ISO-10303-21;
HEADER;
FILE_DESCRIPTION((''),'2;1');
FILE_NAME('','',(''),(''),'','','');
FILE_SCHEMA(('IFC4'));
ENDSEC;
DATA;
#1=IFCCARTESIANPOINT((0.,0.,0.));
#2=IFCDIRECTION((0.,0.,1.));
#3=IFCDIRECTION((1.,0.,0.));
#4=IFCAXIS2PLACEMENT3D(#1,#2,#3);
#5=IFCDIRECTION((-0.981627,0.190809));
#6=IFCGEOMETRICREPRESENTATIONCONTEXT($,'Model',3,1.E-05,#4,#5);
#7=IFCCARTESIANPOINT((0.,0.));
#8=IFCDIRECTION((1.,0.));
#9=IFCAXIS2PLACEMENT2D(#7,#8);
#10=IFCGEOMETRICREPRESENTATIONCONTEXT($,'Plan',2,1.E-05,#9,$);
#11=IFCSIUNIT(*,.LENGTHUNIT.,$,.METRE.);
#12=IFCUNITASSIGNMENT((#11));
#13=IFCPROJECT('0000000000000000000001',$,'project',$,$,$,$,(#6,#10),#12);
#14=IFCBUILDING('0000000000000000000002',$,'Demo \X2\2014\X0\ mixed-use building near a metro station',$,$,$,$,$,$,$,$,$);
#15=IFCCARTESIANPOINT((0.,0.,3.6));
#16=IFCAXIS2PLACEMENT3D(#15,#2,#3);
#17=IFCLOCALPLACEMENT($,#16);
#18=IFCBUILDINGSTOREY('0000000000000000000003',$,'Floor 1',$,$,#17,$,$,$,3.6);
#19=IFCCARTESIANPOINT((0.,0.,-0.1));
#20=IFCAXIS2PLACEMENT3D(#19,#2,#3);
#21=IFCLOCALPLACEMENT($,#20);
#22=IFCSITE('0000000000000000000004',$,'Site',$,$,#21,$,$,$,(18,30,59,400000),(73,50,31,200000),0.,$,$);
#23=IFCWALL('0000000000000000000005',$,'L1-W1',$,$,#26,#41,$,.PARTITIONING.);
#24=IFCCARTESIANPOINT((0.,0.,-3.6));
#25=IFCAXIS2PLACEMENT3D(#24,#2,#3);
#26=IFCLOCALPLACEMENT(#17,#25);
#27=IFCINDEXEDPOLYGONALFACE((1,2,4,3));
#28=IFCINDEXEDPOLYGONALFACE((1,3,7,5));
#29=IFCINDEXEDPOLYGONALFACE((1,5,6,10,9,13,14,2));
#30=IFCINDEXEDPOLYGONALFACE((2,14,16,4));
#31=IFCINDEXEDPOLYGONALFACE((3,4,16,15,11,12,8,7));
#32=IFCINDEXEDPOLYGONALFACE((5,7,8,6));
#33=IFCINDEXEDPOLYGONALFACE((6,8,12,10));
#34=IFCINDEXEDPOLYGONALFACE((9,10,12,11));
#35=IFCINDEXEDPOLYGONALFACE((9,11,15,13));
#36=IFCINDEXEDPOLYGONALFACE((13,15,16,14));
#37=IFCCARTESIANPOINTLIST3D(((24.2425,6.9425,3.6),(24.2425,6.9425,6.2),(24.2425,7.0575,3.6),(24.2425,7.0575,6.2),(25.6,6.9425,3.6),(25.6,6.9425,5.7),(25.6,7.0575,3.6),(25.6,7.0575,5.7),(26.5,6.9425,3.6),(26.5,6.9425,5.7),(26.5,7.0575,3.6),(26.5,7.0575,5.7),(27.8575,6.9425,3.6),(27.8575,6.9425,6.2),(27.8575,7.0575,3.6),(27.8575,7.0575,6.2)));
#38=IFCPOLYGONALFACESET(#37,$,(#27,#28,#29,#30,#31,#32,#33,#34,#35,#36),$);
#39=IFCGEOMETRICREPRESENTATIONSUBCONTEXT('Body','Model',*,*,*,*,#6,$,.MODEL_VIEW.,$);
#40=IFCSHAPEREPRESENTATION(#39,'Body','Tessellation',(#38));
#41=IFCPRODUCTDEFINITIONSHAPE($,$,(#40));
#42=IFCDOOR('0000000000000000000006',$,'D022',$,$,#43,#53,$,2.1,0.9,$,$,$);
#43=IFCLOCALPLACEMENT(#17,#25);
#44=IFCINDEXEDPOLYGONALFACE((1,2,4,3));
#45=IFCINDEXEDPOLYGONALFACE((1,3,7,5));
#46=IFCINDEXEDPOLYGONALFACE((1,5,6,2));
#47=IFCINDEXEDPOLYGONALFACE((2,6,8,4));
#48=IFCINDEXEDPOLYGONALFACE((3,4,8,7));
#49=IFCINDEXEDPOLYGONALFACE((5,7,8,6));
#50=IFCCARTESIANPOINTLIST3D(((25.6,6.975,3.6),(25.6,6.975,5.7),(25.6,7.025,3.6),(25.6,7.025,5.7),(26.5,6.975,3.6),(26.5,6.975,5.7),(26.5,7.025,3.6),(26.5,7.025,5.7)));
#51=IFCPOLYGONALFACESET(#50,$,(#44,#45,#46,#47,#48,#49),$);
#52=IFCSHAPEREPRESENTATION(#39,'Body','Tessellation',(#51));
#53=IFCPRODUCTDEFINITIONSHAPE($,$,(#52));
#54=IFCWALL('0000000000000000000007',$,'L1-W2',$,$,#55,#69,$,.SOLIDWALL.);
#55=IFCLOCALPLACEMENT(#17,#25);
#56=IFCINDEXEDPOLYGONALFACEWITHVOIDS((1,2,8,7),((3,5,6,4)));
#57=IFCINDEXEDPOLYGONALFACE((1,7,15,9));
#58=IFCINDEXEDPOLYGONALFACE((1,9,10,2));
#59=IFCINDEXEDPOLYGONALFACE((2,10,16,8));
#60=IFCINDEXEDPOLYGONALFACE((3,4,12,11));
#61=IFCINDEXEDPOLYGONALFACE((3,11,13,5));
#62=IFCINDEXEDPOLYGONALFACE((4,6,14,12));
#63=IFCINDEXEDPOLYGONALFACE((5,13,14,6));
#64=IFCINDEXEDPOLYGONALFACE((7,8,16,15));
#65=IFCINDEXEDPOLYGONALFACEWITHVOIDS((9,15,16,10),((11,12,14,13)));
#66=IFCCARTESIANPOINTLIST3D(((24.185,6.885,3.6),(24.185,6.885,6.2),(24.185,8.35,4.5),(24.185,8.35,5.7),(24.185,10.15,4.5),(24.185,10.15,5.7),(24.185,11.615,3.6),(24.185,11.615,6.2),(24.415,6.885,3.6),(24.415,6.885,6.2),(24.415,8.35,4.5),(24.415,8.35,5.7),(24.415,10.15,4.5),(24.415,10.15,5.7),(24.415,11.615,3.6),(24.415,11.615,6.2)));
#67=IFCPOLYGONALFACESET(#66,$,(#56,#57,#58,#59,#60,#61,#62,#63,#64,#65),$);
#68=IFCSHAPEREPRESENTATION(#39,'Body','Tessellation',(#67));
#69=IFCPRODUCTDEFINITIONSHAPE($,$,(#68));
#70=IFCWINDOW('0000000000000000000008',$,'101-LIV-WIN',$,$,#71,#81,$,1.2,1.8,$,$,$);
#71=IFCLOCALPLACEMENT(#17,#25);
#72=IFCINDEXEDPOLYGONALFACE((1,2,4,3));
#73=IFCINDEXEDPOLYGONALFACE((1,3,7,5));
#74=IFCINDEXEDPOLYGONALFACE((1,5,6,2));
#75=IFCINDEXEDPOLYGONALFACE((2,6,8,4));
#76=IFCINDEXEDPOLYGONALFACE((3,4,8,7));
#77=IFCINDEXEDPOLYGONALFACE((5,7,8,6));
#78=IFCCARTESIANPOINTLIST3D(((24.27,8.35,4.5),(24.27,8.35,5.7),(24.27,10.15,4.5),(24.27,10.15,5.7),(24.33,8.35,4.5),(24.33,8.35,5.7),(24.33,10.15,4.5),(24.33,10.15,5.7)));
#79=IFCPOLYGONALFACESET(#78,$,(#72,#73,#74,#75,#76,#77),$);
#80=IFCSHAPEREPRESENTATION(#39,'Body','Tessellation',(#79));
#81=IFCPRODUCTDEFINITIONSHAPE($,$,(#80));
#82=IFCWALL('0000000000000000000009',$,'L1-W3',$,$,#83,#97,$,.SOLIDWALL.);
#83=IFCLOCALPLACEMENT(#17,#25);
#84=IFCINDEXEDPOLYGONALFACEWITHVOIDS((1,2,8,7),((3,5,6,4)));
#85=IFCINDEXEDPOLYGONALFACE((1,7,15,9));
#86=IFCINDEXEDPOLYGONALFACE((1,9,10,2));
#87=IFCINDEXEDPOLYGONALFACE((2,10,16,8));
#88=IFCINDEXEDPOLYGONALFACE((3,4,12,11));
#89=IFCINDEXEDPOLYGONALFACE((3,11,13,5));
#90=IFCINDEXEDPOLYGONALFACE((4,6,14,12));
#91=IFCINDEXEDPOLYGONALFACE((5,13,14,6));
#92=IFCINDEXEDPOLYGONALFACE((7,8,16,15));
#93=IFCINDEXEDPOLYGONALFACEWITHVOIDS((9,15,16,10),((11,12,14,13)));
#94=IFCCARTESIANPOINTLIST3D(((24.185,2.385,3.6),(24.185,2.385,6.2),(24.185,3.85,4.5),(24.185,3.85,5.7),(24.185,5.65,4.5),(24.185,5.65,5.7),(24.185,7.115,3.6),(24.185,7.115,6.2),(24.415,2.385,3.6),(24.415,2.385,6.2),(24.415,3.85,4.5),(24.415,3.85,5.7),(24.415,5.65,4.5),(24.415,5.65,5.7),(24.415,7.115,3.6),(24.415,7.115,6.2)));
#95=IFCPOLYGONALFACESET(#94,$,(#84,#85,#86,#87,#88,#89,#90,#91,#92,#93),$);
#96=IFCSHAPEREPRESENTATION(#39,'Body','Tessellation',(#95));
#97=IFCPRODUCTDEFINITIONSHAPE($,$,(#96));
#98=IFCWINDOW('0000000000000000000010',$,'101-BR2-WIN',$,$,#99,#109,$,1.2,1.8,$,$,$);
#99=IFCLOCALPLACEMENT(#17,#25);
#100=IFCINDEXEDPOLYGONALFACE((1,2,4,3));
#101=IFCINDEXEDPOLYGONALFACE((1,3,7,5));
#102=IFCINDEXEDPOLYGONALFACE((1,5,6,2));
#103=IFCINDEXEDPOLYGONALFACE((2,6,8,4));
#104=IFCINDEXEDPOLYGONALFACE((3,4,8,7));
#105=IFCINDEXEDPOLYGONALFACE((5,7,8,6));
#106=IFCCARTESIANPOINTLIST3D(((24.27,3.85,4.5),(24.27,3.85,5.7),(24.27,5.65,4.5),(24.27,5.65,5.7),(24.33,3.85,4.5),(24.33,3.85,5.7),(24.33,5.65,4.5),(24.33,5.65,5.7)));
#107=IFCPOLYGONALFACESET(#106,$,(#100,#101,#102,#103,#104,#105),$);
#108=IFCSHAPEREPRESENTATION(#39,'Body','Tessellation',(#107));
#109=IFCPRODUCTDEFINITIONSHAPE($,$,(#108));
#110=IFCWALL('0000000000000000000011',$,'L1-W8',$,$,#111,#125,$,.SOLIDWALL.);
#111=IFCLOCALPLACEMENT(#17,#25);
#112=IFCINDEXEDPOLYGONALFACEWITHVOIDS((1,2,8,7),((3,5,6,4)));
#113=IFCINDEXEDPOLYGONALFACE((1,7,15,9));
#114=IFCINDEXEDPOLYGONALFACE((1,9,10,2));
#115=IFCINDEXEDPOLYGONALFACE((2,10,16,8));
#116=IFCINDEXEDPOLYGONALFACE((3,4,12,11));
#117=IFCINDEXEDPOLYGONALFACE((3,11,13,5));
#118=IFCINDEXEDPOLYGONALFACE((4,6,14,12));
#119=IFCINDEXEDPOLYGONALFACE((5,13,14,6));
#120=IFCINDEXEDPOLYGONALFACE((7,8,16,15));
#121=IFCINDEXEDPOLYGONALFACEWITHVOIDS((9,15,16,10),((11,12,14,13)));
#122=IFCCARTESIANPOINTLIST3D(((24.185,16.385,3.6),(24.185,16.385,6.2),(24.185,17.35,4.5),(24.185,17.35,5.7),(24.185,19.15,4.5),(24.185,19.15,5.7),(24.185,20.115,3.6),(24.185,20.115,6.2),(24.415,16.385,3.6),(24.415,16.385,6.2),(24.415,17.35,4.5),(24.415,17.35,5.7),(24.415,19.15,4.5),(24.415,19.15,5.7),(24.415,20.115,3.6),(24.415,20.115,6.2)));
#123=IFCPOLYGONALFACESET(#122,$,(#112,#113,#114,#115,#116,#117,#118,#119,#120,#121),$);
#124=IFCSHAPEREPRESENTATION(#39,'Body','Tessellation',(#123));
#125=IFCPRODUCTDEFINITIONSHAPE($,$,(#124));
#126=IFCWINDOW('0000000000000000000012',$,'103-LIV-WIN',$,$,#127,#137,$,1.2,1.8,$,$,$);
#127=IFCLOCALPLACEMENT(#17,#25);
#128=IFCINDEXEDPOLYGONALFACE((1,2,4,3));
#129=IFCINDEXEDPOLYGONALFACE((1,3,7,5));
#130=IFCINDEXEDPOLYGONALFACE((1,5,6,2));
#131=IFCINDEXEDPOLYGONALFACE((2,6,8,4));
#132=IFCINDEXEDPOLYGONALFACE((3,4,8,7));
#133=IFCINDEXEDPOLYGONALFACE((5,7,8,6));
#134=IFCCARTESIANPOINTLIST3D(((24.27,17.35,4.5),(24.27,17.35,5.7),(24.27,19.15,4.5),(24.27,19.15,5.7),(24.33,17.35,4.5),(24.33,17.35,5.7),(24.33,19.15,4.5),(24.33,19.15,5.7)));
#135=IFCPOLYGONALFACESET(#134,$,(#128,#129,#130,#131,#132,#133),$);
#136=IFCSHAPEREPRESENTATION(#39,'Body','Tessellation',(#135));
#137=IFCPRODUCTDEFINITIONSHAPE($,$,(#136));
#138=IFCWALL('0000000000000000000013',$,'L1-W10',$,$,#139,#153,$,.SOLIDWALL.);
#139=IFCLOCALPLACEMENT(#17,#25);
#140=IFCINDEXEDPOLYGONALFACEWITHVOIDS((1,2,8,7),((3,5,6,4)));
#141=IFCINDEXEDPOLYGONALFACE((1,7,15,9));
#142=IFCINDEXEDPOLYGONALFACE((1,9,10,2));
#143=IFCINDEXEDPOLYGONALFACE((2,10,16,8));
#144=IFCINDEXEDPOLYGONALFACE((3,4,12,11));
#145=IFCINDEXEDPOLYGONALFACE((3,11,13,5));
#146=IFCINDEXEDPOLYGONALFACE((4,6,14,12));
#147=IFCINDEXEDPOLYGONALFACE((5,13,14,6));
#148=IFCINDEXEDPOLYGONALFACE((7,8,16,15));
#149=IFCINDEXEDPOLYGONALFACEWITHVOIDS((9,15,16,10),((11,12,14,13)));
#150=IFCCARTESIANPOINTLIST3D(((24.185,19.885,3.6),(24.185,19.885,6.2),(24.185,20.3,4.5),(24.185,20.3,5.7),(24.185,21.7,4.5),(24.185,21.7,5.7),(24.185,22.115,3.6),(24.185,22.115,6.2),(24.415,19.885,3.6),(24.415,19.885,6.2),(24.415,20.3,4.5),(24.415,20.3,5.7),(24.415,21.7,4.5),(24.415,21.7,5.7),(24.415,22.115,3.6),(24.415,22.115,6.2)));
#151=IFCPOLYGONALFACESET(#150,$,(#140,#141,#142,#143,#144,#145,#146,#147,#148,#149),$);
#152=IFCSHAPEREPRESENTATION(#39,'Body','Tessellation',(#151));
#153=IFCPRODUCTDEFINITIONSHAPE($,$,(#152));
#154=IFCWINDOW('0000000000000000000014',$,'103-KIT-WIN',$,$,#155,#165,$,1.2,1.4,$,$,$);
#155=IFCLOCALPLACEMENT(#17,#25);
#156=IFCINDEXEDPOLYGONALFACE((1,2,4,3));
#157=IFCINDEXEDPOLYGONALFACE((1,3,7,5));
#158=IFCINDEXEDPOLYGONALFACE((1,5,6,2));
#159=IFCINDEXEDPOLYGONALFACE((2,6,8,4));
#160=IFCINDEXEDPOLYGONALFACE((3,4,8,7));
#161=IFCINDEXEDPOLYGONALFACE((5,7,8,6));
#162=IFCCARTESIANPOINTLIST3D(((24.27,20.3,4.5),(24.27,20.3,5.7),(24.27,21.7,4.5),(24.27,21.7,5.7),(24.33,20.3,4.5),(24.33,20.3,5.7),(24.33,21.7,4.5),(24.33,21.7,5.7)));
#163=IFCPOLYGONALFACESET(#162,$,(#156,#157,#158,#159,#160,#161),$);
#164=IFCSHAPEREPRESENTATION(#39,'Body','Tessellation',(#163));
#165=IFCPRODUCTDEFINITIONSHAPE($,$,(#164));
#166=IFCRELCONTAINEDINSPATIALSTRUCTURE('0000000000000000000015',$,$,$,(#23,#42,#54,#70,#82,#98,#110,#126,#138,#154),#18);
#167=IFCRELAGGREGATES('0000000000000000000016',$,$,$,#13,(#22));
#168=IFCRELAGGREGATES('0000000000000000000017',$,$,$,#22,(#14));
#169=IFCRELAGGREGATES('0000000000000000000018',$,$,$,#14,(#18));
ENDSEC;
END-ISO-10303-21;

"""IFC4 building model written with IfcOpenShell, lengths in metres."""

from ifc_helpers import new_model, si_unit, direction, frame, origin_with_axes, origin_2d_with_axis, place, context, subcontext, project, spatial, line, indexed_curve, outline, extrude, element, fill, save


model = new_model("IFC4")

# Units and contexts
model_context = context("Model", 3, precision=1e-05, world=origin_with_axes(), true_north=direction((-0.981627, 0.190809)))
plan_context = context("Plan", 2, precision=1e-05, world=origin_2d_with_axis())
body_context = subcontext(model_context, "Body", "Model", "MODEL_VIEW")
ifc_project = project(units=[si_unit("LENGTHUNIT", "METRE")], contexts=[model_context, plan_context])

# Site, building, storey
site_placement = place(None, frame((0.0, 0.0, -0.1), z_axis=(0.0, 0.0, 1.0), x_axis=(1.0, 0.0, 0.0)))
site = spatial("IfcSite", under=ifc_project, at=site_placement, Name="Site", RefLatitude=(18, 30, 59, 400000), RefLongitude=(73, 50, 31, 200000), RefElevation=0.0)
building = spatial("IfcBuilding", under=site, Name="Demo — mixed-use building near a metro station")
storey_placement = place(None, frame((0.0, 0.0, 3.6), z_axis=(0.0, 0.0, 1.0), x_axis=(1.0, 0.0, 0.0)))
storey = spatial("IfcBuildingStorey", under=building, at=storey_placement, Name="Floor 1", Elevation=3.6)

# Wall, opening, door
wall_1_placement = place(storey_placement, frame((0.0, 0.0, -3.6), z_axis=(0.0, 0.0, 1.0), x_axis=(1.0, 0.0, 0.0)))
wall_1 = element("IfcWall", 1, at=wall_1_placement, inside=storey, Name="L1-W1", PredefinedType="PARTITIONING", context=body_context, shape_type="SweptSolid", body=[
    extrude(outline(indexed_curve([(27.8575, 6.9425), (24.2425, 6.9425), (24.2425, 7.0575), (27.8575, 7.0575)], segments=[line(1, 2, 3, 4, 1)])), frame((0.0, 0.0, 3.6), z_axis=(0.0, 0.0, 1.0), x_axis=(1.0, 0.0, 0.0)), (0.0, 0.0, 1.0), 2.6),
])
opening_1_placement = place(wall_1_placement, origin_with_axes())
opening_1 = element("IfcOpeningElement", 2, at=opening_1_placement, cuts=wall_1, context=body_context, shape_type="SweptSolid", body=[
    extrude(outline(indexed_curve([(26.5, 6.8925), (25.6, 6.8925), (25.6, 7.1075), (26.5, 7.1075)], segments=[line(1, 2, 3, 4, 1)])), frame((0.0, 0.0, 3.6), z_axis=(0.0, 0.0, 1.0), x_axis=(1.0, 0.0, 0.0)), (0.0, 0.0, 1.0), 2.1),
])
door_placement = place(storey_placement, frame((0.0, 0.0, -3.6), z_axis=(0.0, 0.0, 1.0), x_axis=(1.0, 0.0, 0.0)))
door = element("IfcDoor", 3, at=door_placement, inside=storey, Name="D022", OverallHeight=2.1, OverallWidth=0.9, context=body_context, shape_type="SweptSolid", body=[
    extrude(outline(indexed_curve([(26.5, 6.975), (25.6, 6.975), (25.6, 7.025), (26.5, 7.025)], segments=[line(1, 2, 3, 4, 1)])), frame((0.0, 0.0, 3.6), z_axis=(0.0, 0.0, 1.0), x_axis=(1.0, 0.0, 0.0)), (0.0, 0.0, 1.0), 2.1),
])
fill(opening_1, door)

# Walls, openings, windows
wall_2_placement = place(storey_placement, frame((0.0, 0.0, -3.6), z_axis=(0.0, 0.0, 1.0), x_axis=(1.0, 0.0, 0.0)))
wall_2 = element("IfcWall", 4, at=wall_2_placement, inside=storey, Name="L1-W2", PredefinedType="SOLIDWALL", context=body_context, shape_type="SweptSolid", body=[
    extrude(outline(indexed_curve([(24.415, 11.615), (24.415, 6.885), (24.185, 6.885), (24.185, 11.615)], segments=[line(1, 2, 3, 4, 1)])), frame((0.0, 0.0, 3.6), z_axis=(0.0, 0.0, 1.0), x_axis=(1.0, 0.0, 0.0)), (0.0, 0.0, 1.0), 2.6),
])
opening_2_placement = place(wall_2_placement, origin_with_axes())
opening_2 = element("IfcOpeningElement", 5, at=opening_2_placement, cuts=wall_2, context=body_context, shape_type="SweptSolid", body=[
    extrude(outline(indexed_curve([(24.465, 10.15), (24.465, 8.35), (24.135, 8.35), (24.135, 10.15)], segments=[line(1, 2, 3, 4, 1)])), frame((0.0, 0.0, 4.5), z_axis=(0.0, 0.0, 1.0), x_axis=(1.0, 0.0, 0.0)), (0.0, 0.0, 1.0), 1.2),
])
window_1_placement = place(storey_placement, frame((0.0, 0.0, -3.6), z_axis=(0.0, 0.0, 1.0), x_axis=(1.0, 0.0, 0.0)))
window_1 = element("IfcWindow", 6, at=window_1_placement, inside=storey, Name="101-LIV-WIN", OverallHeight=1.2, OverallWidth=1.8, context=body_context, shape_type="SweptSolid", body=[
    extrude(outline(indexed_curve([(24.33, 10.15), (24.33, 8.35), (24.27, 8.35), (24.27, 10.15)], segments=[line(1, 2, 3, 4, 1)])), frame((0.0, 0.0, 4.5), z_axis=(0.0, 0.0, 1.0), x_axis=(1.0, 0.0, 0.0)), (0.0, 0.0, 1.0), 1.2),
])
fill(opening_2, window_1)
wall_3_placement = place(storey_placement, frame((0.0, 0.0, -3.6), z_axis=(0.0, 0.0, 1.0), x_axis=(1.0, 0.0, 0.0)))
wall_3 = element("IfcWall", 7, at=wall_3_placement, inside=storey, Name="L1-W3", PredefinedType="SOLIDWALL", context=body_context, shape_type="SweptSolid", body=[
    extrude(outline(indexed_curve([(24.415, 7.115), (24.415, 2.385), (24.185, 2.385), (24.185, 7.115)], segments=[line(1, 2, 3, 4, 1)])), frame((0.0, 0.0, 3.6), z_axis=(0.0, 0.0, 1.0), x_axis=(1.0, 0.0, 0.0)), (0.0, 0.0, 1.0), 2.6),
])
opening_3_placement = place(wall_3_placement, origin_with_axes())
opening_3 = element("IfcOpeningElement", 8, at=opening_3_placement, cuts=wall_3, context=body_context, shape_type="SweptSolid", body=[
    extrude(outline(indexed_curve([(24.465, 5.65), (24.465, 3.85), (24.135, 3.85), (24.135, 5.65)], segments=[line(1, 2, 3, 4, 1)])), frame((0.0, 0.0, 4.5), z_axis=(0.0, 0.0, 1.0), x_axis=(1.0, 0.0, 0.0)), (0.0, 0.0, 1.0), 1.2),
])
window_2_placement = place(storey_placement, frame((0.0, 0.0, -3.6), z_axis=(0.0, 0.0, 1.0), x_axis=(1.0, 0.0, 0.0)))
window_2 = element("IfcWindow", 9, at=window_2_placement, inside=storey, Name="101-BR2-WIN", OverallHeight=1.2, OverallWidth=1.8, context=body_context, shape_type="SweptSolid", body=[
    extrude(outline(indexed_curve([(24.33, 5.65), (24.33, 3.85), (24.27, 3.85), (24.27, 5.65)], segments=[line(1, 2, 3, 4, 1)])), frame((0.0, 0.0, 4.5), z_axis=(0.0, 0.0, 1.0), x_axis=(1.0, 0.0, 0.0)), (0.0, 0.0, 1.0), 1.2),
])
fill(opening_3, window_2)

# Wall, opening, window
wall_4_placement = place(storey_placement, frame((0.0, 0.0, -3.6), z_axis=(0.0, 0.0, 1.0), x_axis=(1.0, 0.0, 0.0)))
wall_4 = element("IfcWall", 10, at=wall_4_placement, inside=storey, Name="L1-W8", PredefinedType="SOLIDWALL", context=body_context, shape_type="SweptSolid", body=[
    extrude(outline(indexed_curve([(24.415, 20.115), (24.415, 16.385), (24.185, 16.385), (24.185, 20.115)], segments=[line(1, 2, 3, 4, 1)])), frame((0.0, 0.0, 3.6), z_axis=(0.0, 0.0, 1.0), x_axis=(1.0, 0.0, 0.0)), (0.0, 0.0, 1.0), 2.6),
])
opening_4_placement = place(wall_4_placement, origin_with_axes())
opening_4 = element("IfcOpeningElement", 11, at=opening_4_placement, cuts=wall_4, context=body_context, shape_type="SweptSolid", body=[
    extrude(outline(indexed_curve([(24.465, 19.15), (24.465, 17.35), (24.135, 17.35), (24.135, 19.15)], segments=[line(1, 2, 3, 4, 1)])), frame((0.0, 0.0, 4.5), z_axis=(0.0, 0.0, 1.0), x_axis=(1.0, 0.0, 0.0)), (0.0, 0.0, 1.0), 1.2),
])
window_3_placement = place(storey_placement, frame((0.0, 0.0, -3.6), z_axis=(0.0, 0.0, 1.0), x_axis=(1.0, 0.0, 0.0)))
window_3 = element("IfcWindow", 12, at=window_3_placement, inside=storey, Name="103-LIV-WIN", OverallHeight=1.2, OverallWidth=1.8, context=body_context, shape_type="SweptSolid", body=[
    extrude(outline(indexed_curve([(24.33, 19.15), (24.33, 17.35), (24.27, 17.35), (24.27, 19.15)], segments=[line(1, 2, 3, 4, 1)])), frame((0.0, 0.0, 4.5), z_axis=(0.0, 0.0, 1.0), x_axis=(1.0, 0.0, 0.0)), (0.0, 0.0, 1.0), 1.2),
])
fill(opening_4, window_3)

# Wall, opening, window
wall_5_placement = place(storey_placement, frame((0.0, 0.0, -3.6), z_axis=(0.0, 0.0, 1.0), x_axis=(1.0, 0.0, 0.0)))
wall_5 = element("IfcWall", 13, at=wall_5_placement, inside=storey, Name="L1-W10", PredefinedType="SOLIDWALL", context=body_context, shape_type="SweptSolid", body=[
    extrude(outline(indexed_curve([(24.415, 22.115), (24.415, 19.885), (24.185, 19.885), (24.185, 22.115)], segments=[line(1, 2, 3, 4, 1)])), frame((0.0, 0.0, 3.6), z_axis=(0.0, 0.0, 1.0), x_axis=(1.0, 0.0, 0.0)), (0.0, 0.0, 1.0), 2.6),
])
opening_5_placement = place(wall_5_placement, origin_with_axes())
opening_5 = element("IfcOpeningElement", 14, at=opening_5_placement, cuts=wall_5, context=body_context, shape_type="SweptSolid", body=[
    extrude(outline(indexed_curve([(24.465, 21.7), (24.465, 20.3), (24.135, 20.3), (24.135, 21.7)], segments=[line(1, 2, 3, 4, 1)])), frame((0.0, 0.0, 4.5), z_axis=(0.0, 0.0, 1.0), x_axis=(1.0, 0.0, 0.0)), (0.0, 0.0, 1.0), 1.2),
])
window_4_placement = place(storey_placement, frame((0.0, 0.0, -3.6), z_axis=(0.0, 0.0, 1.0), x_axis=(1.0, 0.0, 0.0)))
window_4 = element("IfcWindow", 15, at=window_4_placement, inside=storey, Name="103-KIT-WIN", OverallHeight=1.2, OverallWidth=1.4, context=body_context, shape_type="SweptSolid", body=[
    extrude(outline(indexed_curve([(24.33, 21.7), (24.33, 20.3), (24.27, 20.3), (24.27, 21.7)], segments=[line(1, 2, 3, 4, 1)])), frame((0.0, 0.0, 4.5), z_axis=(0.0, 0.0, 1.0), x_axis=(1.0, 0.0, 0.0)), (0.0, 0.0, 1.0), 1.2),
])
fill(opening_5, window_4)

save(model, "model.ifc")
